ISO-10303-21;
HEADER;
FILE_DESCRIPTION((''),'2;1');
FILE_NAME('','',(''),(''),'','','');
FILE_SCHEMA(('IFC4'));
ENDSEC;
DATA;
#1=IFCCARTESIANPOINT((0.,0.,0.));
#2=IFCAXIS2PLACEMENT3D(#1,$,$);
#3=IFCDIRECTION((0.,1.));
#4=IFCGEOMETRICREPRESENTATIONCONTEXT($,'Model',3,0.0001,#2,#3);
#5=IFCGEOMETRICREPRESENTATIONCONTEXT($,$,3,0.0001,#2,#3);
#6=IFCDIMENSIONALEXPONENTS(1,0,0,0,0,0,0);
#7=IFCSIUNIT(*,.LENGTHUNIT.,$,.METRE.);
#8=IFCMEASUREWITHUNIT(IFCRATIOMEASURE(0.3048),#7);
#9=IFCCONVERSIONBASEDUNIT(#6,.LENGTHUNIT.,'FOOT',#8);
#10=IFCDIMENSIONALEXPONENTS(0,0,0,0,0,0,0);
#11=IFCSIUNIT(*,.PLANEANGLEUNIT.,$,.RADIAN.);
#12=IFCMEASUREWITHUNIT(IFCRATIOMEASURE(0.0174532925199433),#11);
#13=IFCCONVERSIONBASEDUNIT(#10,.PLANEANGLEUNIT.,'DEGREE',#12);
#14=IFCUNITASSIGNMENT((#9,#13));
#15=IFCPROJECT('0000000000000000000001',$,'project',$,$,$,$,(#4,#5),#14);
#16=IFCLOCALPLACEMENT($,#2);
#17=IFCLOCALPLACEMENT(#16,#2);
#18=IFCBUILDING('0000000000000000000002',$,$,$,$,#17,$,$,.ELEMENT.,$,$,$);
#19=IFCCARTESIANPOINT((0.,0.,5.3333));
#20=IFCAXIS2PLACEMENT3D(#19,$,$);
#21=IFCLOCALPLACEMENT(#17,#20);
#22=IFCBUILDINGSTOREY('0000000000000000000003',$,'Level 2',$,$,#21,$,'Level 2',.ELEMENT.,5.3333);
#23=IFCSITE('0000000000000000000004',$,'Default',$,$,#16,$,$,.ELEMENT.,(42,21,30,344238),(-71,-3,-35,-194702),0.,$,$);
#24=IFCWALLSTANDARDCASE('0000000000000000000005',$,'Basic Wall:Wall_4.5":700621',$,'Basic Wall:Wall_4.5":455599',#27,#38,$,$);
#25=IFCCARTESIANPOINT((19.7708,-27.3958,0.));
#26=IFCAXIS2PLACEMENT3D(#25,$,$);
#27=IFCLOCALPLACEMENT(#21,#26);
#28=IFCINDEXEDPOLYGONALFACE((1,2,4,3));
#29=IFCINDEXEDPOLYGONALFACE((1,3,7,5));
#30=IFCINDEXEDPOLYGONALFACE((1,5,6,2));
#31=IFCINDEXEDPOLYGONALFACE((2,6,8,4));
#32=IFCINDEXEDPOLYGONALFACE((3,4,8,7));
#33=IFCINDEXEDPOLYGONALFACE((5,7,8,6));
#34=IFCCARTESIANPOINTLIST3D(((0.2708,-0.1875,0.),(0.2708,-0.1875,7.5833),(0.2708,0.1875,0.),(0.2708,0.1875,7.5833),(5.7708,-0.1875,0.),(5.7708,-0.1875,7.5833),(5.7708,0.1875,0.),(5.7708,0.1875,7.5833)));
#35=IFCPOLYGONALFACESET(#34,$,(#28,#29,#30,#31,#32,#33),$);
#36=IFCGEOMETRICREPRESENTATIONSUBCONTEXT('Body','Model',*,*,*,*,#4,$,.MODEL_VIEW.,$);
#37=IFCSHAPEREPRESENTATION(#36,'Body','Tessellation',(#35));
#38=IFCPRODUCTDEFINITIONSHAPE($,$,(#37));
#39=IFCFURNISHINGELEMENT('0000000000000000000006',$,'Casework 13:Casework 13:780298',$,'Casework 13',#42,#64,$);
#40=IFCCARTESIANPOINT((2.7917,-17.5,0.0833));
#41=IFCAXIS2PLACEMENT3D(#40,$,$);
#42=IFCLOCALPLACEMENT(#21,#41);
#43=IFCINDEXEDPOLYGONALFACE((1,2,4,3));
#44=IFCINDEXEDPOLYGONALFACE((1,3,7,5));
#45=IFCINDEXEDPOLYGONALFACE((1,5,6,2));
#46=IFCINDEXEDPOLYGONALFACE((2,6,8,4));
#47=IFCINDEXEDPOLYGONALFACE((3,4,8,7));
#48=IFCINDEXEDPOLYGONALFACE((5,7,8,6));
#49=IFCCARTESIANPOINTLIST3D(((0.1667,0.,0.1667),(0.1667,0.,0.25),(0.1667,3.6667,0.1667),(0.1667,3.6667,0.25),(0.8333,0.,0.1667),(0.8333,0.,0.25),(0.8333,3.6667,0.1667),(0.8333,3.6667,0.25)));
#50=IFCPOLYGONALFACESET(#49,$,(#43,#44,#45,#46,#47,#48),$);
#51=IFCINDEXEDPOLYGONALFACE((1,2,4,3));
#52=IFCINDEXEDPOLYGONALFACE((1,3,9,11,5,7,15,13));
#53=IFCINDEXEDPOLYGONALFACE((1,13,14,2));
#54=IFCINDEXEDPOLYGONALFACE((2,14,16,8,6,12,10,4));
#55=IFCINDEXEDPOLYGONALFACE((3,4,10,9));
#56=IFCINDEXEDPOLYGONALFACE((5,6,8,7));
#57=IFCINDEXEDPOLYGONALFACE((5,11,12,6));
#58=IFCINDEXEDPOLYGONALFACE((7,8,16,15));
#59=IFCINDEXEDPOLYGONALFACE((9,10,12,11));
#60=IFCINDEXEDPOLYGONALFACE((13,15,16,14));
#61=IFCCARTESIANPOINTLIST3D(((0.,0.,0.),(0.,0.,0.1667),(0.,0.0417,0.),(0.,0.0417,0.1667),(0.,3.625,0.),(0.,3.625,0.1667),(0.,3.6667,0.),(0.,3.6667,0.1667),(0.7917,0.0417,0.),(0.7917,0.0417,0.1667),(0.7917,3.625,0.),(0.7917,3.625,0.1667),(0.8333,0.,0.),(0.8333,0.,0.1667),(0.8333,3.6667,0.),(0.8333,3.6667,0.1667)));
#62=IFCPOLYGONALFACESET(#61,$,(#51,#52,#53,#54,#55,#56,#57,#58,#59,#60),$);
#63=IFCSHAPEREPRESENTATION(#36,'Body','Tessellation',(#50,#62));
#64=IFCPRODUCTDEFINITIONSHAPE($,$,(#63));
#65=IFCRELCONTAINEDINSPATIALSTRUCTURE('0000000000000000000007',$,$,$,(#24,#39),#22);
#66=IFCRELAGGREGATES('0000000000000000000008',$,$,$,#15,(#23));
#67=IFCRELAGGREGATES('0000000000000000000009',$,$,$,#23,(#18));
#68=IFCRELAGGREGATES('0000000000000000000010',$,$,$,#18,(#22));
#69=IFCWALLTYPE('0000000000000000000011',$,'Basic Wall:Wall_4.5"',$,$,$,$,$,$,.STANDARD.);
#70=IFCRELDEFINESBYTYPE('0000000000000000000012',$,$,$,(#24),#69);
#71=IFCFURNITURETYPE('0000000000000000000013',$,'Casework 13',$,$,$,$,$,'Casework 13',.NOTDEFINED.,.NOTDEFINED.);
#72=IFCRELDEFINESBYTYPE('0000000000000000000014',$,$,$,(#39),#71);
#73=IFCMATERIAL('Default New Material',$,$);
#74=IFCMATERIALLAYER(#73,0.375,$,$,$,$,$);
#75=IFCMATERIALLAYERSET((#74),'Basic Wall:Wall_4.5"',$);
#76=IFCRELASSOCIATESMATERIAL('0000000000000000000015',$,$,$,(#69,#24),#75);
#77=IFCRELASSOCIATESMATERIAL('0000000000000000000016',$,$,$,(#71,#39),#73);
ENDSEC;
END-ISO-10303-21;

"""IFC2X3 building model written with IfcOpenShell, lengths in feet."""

from ifc_helpers import new_model, entity, si_unit, converted_unit, direction, frame, frame_2d, origin, place, context, subcontext, project, spatial, polyline, rectangle, outline, extrude, source, transform, mapped, material, layer, layer_set, layer_usage, type_object, type_shapes, element, save


model = new_model("IFC2X3")

# Units and contexts
model_context = context("Model", 3, precision=0.0001, world=origin(), true_north=direction((0.0, 1.0)))
context_of_model = context(None, 3, precision=0.0001, world=origin(), true_north=direction((0.0, 1.0)))
body_context = subcontext(model_context, "Body", "Model", "MODEL_VIEW")
ifc_project = project(units=[converted_unit("LENGTHUNIT", "FOOT", entity("IfcRatioMeasure", 0.3048), si_unit("LENGTHUNIT", "METRE"), dimensions=[1, 0, 0, 0, 0, 0, 0]), converted_unit("PLANEANGLEUNIT", "DEGREE", entity("IfcRatioMeasure", 0.0174532925199433), si_unit("PLANEANGLEUNIT", "RADIAN"), dimensions=[0, 0, 0, 0, 0, 0, 0])], contexts=[model_context, context_of_model])

# Site, building, storey
site_placement = place(None, origin())
site = spatial("IfcSite", under=ifc_project, at=site_placement, Name="Default", CompositionType="ELEMENT", RefLatitude=(42, 21, 30, 344238), RefLongitude=(-71, -3, -35, -194702), RefElevation=0.0)
building_placement = place(site_placement, origin())
building = spatial("IfcBuilding", under=site, at=building_placement, CompositionType="ELEMENT")
storey_placement = place(building_placement, frame((0.0, 0.0, 5.3333)))
storey = spatial("IfcBuildingStorey", under=building, at=storey_placement, Name="Level 2", LongName="Level 2", CompositionType="ELEMENT", Elevation=5.3333)

# Shared definitions
ifc_material_1 = material(Name="Default New Material")

# Wall
ifc_layer_1 = layer(ifc_material_1, 0.375)
ifc_layer_set_1 = layer_set([ifc_layer_1], Name="Basic Wall:Wall_4.5\"")
ifc_layer_usage_1 = layer_usage(ifc_layer_set_1, "AXIS2", "POSITIVE", -0.1875)
wall_type_1 = type_object("IfcWallType", Name="Basic Wall:Wall_4.5\"", PredefinedType="STANDARD", material=ifc_layer_set_1)
wall_1_placement = place(storey_placement, frame((19.7708, -27.3958, 0.0)))
element("IfcWallStandardCase", 1, at=wall_1_placement, inside=storey, type_object=wall_type_1, material=ifc_layer_usage_1, Name="Basic Wall:Wall_4.5\":700621", ObjectType="Basic Wall:Wall_4.5\":455599", context=body_context, shape_type="SweptSolid", body=[
    extrude(rectangle(XDim=5.5, YDim=0.375, at=frame_2d((3.0208, 0.0), x_axis=(-1.0, 0.0))), origin(), (0.0, 0.0, 1.0), 7.5833),
])

# Furnishing element
furniture_type_1 = type_object("IfcFurnitureType", Name="Casework 13", ElementType="Casework 13", AssemblyPlace="NOTDEFINED", material=ifc_material_1)
shared_shape_1 = source(origin(), body_context, "Body", "SweptSolid", [
    extrude(rectangle(XDim=0.6667, YDim=3.6667, at=frame_2d((0.0, 0.0), x_axis=(1.0, 0.0))), frame((0.5, 1.8333, 0.1667)), (0.0, 0.0, 1.0), 0.0833),
    extrude(outline(polyline([(-0.4063, -1.7917), (-0.4063, -1.8333), (0.4271, -1.8333), (0.4271, 1.8333), (-0.4062, 1.8333), (-0.4062, 1.7917), (0.3854, 1.7917), (0.3854, -1.7917), (-0.4063, -1.7917)])), frame((0.4063, 1.8333, 0.0), z_axis=(0.0, 0.0, -1.0), x_axis=(1.0, 0.0, 0.0)), (0.0, 0.0, -1.0), 0.1667),
])
type_shapes(furniture_type_1, [shared_shape_1])
furnishing_1_placement = place(storey_placement, frame((2.7917, -17.5, 0.0833)))
element("IfcFurnishingElement", 2, at=furnishing_1_placement, inside=storey, type_object=furniture_type_1, material=ifc_material_1, Name="Casework 13:Casework 13:780298", ObjectType="Casework 13", context=body_context, shape_type="MappedRepresentation", body=[
    mapped(shared_shape_1, transform((0.0, 0.0, 0.0), scale=1.0)),
])

save(model, "model.ifc")
